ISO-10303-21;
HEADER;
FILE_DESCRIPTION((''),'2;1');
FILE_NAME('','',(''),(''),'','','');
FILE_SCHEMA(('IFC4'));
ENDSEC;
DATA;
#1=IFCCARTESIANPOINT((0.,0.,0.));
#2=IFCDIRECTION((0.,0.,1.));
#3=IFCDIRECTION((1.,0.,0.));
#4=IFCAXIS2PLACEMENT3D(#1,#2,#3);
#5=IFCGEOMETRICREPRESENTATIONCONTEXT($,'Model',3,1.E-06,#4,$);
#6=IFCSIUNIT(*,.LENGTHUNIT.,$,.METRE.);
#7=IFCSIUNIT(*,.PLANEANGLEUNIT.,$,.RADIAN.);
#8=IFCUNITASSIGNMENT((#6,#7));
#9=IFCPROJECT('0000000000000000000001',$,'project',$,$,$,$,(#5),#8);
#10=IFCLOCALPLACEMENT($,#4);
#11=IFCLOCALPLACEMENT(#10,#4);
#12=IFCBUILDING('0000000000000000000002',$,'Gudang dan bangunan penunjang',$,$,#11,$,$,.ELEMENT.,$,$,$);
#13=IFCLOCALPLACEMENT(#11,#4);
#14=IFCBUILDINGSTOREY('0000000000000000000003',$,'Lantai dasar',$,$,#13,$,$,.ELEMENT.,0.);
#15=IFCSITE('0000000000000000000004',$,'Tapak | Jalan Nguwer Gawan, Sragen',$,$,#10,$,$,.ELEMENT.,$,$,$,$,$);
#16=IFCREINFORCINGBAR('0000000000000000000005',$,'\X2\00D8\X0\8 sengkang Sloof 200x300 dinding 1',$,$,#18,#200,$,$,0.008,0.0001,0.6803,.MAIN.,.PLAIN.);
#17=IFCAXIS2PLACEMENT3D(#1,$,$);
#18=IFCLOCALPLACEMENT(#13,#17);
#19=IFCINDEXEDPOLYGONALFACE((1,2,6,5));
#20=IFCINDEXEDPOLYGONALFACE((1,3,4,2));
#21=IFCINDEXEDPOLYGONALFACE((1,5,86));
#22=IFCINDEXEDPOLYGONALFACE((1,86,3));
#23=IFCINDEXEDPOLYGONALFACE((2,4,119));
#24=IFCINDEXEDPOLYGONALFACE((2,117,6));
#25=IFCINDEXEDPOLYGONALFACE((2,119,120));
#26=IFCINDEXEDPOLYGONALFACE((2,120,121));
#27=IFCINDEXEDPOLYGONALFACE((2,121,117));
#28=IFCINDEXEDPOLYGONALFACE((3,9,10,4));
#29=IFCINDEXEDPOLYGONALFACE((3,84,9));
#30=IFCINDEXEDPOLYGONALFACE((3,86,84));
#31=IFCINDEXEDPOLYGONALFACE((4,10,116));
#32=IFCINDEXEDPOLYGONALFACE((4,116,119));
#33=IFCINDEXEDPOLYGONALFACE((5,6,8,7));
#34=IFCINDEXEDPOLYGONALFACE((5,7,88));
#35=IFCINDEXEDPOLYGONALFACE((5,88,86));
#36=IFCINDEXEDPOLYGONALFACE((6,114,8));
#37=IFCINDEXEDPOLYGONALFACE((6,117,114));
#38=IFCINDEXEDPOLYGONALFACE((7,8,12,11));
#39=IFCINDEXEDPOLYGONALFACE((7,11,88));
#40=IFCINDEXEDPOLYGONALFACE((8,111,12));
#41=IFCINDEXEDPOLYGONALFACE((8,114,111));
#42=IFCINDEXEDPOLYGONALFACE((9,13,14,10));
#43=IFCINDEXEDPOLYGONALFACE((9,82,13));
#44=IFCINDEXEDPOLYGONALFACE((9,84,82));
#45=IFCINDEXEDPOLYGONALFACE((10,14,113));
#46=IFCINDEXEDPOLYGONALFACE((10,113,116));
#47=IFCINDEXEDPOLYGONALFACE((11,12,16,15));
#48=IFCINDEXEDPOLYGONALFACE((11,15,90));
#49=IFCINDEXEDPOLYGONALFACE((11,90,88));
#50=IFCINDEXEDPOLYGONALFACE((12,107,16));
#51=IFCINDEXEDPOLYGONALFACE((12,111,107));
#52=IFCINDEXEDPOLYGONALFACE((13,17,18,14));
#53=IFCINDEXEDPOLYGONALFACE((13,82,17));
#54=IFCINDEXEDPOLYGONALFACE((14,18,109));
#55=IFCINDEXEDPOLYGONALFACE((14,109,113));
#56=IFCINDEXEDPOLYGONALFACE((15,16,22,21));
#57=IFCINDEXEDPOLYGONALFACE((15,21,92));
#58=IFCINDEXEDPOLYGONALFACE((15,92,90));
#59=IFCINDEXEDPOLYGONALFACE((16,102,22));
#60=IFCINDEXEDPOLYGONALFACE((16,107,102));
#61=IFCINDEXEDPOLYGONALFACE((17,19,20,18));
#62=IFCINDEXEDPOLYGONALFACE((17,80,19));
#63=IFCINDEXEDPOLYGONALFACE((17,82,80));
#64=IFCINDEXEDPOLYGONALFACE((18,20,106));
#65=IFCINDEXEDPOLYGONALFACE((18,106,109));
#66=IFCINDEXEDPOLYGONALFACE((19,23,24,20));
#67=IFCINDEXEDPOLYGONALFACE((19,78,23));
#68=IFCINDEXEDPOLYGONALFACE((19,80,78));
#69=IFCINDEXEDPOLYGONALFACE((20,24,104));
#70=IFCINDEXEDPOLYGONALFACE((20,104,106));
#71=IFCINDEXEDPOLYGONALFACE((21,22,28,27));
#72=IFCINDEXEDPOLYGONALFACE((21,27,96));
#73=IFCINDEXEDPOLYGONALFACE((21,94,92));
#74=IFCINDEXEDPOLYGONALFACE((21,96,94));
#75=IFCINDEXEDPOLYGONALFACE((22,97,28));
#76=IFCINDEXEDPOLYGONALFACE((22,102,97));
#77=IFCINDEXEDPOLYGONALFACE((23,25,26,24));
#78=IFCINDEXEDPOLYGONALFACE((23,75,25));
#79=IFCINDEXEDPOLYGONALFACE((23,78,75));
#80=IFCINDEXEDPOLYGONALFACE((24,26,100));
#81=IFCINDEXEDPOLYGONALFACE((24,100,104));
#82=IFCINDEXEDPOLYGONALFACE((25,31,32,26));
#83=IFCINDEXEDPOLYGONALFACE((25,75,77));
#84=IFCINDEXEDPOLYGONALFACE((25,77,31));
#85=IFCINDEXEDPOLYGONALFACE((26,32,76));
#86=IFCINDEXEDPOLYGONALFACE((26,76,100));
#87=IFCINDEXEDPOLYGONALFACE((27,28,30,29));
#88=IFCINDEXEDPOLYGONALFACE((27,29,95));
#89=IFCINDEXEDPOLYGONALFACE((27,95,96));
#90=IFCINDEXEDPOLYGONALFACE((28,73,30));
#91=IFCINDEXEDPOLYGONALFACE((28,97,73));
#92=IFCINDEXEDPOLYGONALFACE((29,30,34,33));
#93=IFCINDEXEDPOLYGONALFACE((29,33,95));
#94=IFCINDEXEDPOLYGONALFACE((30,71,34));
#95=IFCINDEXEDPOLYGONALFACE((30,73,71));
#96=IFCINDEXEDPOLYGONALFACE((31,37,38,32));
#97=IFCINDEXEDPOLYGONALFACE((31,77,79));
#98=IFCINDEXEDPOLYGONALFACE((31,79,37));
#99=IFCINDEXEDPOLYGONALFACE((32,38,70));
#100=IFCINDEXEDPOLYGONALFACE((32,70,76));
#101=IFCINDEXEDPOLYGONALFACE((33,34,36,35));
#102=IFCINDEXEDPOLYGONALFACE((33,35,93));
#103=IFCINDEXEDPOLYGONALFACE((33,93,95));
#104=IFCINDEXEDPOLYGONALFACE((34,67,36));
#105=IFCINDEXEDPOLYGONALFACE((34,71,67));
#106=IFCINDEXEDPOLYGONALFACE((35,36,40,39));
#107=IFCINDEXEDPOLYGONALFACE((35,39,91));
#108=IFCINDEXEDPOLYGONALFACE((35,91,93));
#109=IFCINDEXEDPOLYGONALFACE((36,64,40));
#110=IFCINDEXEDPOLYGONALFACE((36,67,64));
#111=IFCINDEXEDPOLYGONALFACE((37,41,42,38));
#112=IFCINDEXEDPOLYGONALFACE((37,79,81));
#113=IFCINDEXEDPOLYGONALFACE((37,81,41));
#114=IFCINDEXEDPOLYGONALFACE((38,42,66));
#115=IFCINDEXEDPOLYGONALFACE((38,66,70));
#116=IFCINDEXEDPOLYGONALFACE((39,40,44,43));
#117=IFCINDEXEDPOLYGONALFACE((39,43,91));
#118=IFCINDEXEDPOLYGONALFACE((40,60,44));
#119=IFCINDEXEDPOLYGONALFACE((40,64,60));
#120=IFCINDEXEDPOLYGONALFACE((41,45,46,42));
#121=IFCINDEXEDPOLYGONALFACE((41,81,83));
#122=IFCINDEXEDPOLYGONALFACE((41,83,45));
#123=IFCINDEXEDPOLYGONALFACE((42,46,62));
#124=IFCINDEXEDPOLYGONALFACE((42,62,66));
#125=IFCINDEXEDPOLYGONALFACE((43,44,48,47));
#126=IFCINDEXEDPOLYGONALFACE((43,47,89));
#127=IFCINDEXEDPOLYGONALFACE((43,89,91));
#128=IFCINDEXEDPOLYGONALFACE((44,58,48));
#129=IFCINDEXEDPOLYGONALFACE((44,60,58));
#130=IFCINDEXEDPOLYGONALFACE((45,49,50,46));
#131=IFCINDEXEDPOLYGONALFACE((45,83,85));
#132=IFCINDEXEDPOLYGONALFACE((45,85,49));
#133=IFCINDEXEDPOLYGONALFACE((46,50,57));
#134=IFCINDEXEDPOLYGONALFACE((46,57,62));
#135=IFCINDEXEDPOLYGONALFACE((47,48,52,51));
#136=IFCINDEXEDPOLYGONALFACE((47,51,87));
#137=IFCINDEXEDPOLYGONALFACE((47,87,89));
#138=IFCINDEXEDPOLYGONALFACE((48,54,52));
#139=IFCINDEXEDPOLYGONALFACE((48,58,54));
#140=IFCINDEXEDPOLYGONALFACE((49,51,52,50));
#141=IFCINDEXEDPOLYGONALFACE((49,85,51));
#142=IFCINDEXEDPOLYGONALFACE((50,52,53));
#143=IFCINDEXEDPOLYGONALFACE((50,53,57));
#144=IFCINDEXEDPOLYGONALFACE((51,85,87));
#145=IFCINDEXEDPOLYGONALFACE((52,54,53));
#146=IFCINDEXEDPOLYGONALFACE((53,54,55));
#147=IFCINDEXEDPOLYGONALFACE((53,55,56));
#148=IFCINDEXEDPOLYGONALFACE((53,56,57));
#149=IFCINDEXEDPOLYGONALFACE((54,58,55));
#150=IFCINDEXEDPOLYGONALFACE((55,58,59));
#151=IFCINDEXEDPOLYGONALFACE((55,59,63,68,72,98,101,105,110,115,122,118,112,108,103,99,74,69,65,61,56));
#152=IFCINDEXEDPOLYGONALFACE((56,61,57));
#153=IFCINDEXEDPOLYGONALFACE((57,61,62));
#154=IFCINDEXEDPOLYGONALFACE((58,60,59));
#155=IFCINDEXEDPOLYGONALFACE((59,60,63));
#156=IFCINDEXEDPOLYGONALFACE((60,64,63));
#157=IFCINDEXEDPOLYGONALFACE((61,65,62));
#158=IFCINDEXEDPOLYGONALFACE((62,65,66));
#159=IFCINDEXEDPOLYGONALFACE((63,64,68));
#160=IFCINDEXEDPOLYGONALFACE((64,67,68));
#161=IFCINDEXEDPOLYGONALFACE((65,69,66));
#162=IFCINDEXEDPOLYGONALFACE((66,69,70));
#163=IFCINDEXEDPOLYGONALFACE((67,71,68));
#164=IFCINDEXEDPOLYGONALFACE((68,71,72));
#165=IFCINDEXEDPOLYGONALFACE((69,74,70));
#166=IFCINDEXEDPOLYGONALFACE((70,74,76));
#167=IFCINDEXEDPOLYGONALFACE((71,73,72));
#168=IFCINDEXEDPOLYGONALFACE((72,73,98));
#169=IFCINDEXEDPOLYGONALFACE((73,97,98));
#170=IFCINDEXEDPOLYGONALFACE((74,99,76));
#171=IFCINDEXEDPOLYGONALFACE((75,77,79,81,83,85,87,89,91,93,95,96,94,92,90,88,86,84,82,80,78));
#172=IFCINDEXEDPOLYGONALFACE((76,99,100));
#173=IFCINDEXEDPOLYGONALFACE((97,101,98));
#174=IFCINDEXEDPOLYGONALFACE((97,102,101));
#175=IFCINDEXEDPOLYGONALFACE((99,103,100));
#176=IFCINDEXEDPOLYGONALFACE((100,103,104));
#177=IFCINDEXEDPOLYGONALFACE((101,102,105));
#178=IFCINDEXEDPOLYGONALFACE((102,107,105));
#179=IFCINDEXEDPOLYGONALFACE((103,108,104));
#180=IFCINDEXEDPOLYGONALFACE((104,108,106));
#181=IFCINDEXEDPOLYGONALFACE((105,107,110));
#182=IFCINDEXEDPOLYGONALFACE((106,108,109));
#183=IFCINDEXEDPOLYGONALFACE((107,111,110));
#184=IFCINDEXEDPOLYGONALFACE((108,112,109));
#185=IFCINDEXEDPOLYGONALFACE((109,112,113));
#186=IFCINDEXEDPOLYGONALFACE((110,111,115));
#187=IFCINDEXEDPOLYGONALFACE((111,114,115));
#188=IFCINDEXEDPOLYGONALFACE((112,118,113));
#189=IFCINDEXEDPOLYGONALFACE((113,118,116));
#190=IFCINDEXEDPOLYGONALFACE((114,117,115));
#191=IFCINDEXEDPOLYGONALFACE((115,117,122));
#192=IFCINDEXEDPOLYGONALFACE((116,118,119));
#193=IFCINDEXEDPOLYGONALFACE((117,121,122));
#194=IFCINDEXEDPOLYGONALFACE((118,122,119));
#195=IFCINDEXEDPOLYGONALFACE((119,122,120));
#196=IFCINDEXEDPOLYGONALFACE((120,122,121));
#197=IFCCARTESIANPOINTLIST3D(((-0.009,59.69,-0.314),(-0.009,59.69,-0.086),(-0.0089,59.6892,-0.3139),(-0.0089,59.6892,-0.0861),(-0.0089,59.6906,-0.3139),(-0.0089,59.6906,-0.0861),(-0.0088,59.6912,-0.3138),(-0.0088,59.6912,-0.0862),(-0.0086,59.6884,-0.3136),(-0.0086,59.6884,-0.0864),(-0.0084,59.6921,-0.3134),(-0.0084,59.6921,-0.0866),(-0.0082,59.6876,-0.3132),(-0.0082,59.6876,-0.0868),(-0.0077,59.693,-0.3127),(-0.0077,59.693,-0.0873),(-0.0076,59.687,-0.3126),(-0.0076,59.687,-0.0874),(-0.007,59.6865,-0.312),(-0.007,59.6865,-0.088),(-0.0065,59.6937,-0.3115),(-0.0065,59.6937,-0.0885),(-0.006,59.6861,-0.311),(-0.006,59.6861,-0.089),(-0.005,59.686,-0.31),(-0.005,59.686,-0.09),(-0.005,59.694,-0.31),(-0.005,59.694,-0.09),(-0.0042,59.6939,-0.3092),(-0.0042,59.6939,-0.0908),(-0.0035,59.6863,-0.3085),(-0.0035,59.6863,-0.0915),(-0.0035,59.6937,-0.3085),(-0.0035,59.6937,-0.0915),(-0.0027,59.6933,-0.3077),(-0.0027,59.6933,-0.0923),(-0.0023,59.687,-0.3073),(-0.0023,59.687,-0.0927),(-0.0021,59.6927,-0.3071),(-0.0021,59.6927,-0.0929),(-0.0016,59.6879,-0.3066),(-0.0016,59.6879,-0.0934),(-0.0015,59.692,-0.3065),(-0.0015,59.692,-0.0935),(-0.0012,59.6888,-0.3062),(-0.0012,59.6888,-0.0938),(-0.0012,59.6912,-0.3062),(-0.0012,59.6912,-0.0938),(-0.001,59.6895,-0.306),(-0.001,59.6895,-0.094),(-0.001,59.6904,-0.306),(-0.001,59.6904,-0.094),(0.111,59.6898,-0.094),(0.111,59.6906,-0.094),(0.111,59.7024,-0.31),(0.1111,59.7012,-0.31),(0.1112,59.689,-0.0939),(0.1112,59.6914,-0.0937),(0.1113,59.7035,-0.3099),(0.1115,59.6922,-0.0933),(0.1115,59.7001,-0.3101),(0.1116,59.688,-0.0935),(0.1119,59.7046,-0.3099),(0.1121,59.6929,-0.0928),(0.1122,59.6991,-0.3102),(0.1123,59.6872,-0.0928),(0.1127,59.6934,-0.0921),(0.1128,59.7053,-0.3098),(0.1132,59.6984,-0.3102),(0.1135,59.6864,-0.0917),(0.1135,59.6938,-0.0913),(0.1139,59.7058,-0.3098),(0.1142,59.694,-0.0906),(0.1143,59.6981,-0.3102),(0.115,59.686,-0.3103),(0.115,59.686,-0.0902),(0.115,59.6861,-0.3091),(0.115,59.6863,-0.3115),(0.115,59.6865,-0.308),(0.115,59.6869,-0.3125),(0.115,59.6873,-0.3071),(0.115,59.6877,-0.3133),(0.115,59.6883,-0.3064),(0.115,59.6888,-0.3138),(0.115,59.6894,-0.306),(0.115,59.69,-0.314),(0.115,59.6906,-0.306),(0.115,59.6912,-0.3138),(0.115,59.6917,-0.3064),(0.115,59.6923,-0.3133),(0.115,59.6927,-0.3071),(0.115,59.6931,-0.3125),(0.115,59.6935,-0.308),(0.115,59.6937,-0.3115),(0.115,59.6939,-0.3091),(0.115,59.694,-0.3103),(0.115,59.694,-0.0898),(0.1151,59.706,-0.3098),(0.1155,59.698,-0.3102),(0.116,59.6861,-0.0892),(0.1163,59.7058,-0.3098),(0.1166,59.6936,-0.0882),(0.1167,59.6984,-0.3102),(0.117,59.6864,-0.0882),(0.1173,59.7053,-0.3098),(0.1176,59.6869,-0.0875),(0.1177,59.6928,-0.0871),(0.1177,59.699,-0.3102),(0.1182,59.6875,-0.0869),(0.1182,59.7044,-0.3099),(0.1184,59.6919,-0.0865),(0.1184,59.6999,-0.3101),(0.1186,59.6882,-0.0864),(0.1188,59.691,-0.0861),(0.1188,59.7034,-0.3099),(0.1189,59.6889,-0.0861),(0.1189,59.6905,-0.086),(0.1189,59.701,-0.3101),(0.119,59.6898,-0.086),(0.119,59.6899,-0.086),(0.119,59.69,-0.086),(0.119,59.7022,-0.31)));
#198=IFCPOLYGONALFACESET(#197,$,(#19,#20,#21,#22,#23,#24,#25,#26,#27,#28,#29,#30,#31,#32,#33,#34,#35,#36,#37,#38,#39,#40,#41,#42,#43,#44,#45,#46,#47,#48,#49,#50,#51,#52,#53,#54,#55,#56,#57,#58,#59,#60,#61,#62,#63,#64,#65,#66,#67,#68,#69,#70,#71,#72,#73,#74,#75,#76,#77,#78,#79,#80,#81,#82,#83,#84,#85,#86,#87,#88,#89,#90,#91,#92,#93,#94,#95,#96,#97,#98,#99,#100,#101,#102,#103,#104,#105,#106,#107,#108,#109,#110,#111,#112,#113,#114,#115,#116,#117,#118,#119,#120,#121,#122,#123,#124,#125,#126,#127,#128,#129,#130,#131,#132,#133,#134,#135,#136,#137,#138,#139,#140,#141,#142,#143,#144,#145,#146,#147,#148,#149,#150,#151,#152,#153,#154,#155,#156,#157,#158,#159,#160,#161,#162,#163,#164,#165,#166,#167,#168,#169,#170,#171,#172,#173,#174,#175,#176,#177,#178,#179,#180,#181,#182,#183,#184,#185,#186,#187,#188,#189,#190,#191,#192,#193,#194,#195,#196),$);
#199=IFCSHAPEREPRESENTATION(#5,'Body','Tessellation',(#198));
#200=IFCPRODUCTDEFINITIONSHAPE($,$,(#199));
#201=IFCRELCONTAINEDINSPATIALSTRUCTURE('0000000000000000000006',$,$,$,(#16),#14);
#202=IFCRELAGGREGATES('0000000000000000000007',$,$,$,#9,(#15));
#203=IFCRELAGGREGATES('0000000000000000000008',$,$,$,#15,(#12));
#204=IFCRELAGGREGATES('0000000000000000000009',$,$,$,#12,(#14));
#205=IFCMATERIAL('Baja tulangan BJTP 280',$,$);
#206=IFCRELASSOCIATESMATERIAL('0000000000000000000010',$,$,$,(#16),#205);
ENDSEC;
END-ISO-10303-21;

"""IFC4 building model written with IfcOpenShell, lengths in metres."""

from ifc_helpers import new_model, entity, si_unit, origin_with_axes, place, context, project, spatial, material, element, save


model = new_model("IFC4")

# Units and contexts
model_context = context("Model", 3, precision=1e-06, world=origin_with_axes())
ifc_project = project(units=[si_unit("LENGTHUNIT", "METRE"), si_unit("PLANEANGLEUNIT", "RADIAN")], contexts=[model_context])

# Site, building, storey
site_placement = place(None, origin_with_axes())
site = spatial("IfcSite", under=ifc_project, at=site_placement, Name="Tapak | Jalan Nguwer Gawan, Sragen", CompositionType="ELEMENT")
building_placement = place(site_placement, origin_with_axes())
building = spatial("IfcBuilding", under=site, at=building_placement, Name="Gudang dan bangunan penunjang", CompositionType="ELEMENT")
storey_placement = place(building_placement, origin_with_axes())
storey = spatial("IfcBuildingStorey", under=building, at=storey_placement, Name="Lantai dasar", CompositionType="ELEMENT", Elevation=0.0)

# Shared definitions
placement = place(None, origin_with_axes())

# Reinforcing bar
ifc_material_1 = material(Name="Baja tulangan BJTP 280")
element("IfcReinforcingBar", 1, at=placement, inside=storey, material=ifc_material_1, Name="Ø8 sengkang Sloof 200x300 dinding 1", BarLength=0.6803, BarSurface="PLAIN", CrossSectionArea=0.0001, NominalDiameter=0.008, PredefinedType="MAIN", context=model_context, shape_type="AdvancedSweptSolid", body=[
    entity("IfcSweptDiskSolid", entity("IfcPolyline", [entity("IfcCartesianPoint", [0.115, 59.69, -0.31]), entity("IfcCartesianPoint", [-0.005, 59.69, -0.31]), entity("IfcCartesianPoint", [-0.005, 59.69, -0.09]), entity("IfcCartesianPoint", [0.115, 59.69, -0.09]), entity("IfcCartesianPoint", [0.115, 59.702, -0.31])]), 0.004),
])

save(model, "model.ifc")
